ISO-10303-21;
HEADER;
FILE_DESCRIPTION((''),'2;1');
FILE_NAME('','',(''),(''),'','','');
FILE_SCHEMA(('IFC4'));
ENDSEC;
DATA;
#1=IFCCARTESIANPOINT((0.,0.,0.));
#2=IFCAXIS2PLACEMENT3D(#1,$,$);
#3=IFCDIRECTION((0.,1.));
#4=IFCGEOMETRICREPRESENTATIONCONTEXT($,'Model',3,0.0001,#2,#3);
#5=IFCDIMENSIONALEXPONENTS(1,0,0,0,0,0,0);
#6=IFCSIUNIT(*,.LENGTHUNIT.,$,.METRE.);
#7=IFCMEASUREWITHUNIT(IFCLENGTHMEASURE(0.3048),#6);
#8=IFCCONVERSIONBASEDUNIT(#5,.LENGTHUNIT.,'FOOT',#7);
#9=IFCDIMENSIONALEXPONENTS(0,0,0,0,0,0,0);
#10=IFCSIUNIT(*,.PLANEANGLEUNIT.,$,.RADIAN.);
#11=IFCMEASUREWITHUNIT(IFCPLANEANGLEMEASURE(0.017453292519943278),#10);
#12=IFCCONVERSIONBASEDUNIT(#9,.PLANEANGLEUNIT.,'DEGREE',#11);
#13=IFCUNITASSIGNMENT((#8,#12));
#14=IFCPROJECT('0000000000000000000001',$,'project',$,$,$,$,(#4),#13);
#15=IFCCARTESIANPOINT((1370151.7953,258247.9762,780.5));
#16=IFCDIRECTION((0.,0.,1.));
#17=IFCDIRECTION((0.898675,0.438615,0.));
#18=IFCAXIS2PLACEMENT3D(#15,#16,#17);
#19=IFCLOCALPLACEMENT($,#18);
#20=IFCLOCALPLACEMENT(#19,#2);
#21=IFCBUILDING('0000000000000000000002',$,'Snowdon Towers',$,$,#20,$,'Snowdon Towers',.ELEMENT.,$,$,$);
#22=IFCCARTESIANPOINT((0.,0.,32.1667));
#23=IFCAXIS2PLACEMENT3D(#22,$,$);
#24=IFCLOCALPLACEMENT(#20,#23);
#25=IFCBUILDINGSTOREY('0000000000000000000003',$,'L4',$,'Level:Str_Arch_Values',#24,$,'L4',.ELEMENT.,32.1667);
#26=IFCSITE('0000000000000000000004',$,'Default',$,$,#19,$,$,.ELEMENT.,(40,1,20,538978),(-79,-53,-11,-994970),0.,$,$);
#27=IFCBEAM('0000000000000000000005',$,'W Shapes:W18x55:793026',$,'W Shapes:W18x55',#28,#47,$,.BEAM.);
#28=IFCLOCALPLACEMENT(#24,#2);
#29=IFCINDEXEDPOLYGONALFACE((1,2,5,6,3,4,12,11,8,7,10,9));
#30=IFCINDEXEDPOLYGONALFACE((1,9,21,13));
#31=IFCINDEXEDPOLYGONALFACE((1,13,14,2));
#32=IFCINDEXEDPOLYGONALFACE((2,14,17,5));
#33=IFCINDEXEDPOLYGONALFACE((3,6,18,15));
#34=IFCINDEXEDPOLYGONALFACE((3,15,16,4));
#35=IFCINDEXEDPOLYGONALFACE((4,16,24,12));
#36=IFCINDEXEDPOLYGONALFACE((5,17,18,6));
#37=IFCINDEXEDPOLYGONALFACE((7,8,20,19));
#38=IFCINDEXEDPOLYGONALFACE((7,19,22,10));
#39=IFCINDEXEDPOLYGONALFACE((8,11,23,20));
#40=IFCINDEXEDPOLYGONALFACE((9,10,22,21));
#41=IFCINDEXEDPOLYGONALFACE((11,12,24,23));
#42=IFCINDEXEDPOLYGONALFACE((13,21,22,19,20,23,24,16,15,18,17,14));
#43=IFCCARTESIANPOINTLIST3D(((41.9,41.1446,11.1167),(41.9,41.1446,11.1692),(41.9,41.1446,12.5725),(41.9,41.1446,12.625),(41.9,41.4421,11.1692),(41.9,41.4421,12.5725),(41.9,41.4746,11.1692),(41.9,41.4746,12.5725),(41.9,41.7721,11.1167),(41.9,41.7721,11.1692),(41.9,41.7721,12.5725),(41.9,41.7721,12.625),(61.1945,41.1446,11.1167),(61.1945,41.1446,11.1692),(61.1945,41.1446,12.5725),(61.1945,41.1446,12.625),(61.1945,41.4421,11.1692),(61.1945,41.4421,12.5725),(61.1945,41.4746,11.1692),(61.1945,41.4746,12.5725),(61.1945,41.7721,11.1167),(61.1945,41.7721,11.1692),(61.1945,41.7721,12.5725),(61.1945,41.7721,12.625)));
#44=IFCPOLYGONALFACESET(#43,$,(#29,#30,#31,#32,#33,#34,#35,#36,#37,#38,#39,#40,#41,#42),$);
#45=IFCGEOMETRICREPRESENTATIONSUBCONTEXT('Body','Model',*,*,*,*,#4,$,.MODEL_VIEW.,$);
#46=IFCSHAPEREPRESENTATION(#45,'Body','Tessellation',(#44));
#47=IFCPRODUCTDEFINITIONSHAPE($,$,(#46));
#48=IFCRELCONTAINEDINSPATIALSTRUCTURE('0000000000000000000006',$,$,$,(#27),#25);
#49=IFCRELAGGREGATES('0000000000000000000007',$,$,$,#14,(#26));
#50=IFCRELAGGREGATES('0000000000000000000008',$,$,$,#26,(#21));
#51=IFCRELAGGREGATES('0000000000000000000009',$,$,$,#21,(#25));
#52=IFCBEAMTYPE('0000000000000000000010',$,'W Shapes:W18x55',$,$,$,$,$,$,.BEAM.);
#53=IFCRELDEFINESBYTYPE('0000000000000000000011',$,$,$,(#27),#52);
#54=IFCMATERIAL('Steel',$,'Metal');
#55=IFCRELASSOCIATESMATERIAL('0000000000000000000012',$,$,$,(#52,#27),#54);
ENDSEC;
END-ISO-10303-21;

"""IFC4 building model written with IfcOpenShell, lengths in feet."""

from ifc_helpers import new_model, entity, si_unit, converted_unit, direction, frame, origin, place, context, subcontext, project, spatial, indexed_curve, outline, extrude, source, transform, mapped, material, type_object, type_shapes, element, save


model = new_model("IFC4")

# Units and contexts
model_context = context("Model", 3, precision=0.0001, world=origin(), true_north=direction((0.0, 1.0)))
body_context = subcontext(model_context, "Body", "Model", "MODEL_VIEW")
ifc_project = project(units=[converted_unit("LENGTHUNIT", "FOOT", entity("IfcLengthMeasure", 0.3048), si_unit("LENGTHUNIT", "METRE"), dimensions=[1, 0, 0, 0, 0, 0, 0]), converted_unit("PLANEANGLEUNIT", "DEGREE", entity("IfcPlaneAngleMeasure", 0.017453292519943278), si_unit("PLANEANGLEUNIT", "RADIAN"), dimensions=[0, 0, 0, 0, 0, 0, 0])], contexts=[model_context])

# Site, building, storey
site_placement = place(None, frame((1370151.7953, 258247.9762, 780.5), z_axis=(0.0, 0.0, 1.0), x_axis=(0.898675, 0.438615, 0.0)))
site = spatial("IfcSite", under=ifc_project, at=site_placement, Name="Default", CompositionType="ELEMENT", RefLatitude=(40, 1, 20, 538978), RefLongitude=(-79, -53, -11, -994970), RefElevation=0.0)
building_placement = place(site_placement, origin())
building = spatial("IfcBuilding", under=site, at=building_placement, Name="Snowdon Towers", LongName="Snowdon Towers", CompositionType="ELEMENT")
storey_placement = place(building_placement, frame((0.0, 0.0, 32.1667)))
storey = spatial("IfcBuildingStorey", under=building, at=storey_placement, Name="L4", ObjectType="Level:Str_Arch_Values", LongName="L4", CompositionType="ELEMENT", Elevation=32.1667)

# Shared definitions
ifc_material = material(Name="Steel", Category="Metal")

# Beam
beam_type_1 = type_object("IfcBeamType", Name="W Shapes:W18x55", PredefinedType="BEAM", material=ifc_material)
shared_shape_1 = source(origin(), body_context, "Body", "SweptSolid", [
    extrude(outline(indexed_curve([(-0.3138, -0.7017), (-0.3138, -0.7542), (0.3138, -0.7542), (0.3138, -0.7017), (0.0162, -0.7017), (0.0162, 0.7017), (0.3138, 0.7017), (0.3138, 0.7542), (-0.3137, 0.7542), (-0.3137, 0.7017), (-0.0163, 0.7017), (-0.0163, -0.7017), (-0.3138, -0.7017)], self_intersect=False)), frame((-9.9242, 0.0, 0.0), z_axis=(-1.0, 0.0, 0.0), x_axis=(0.0, -1.0, 0.0)), (0.0, 0.0, -1.0), 19.2945),
])
type_shapes(beam_type_1, [shared_shape_1])
beam_1_placement = place(storey_placement, frame((51.8242, 41.4583, 11.8708)))
element("IfcBeam", 1, at=beam_1_placement, inside=storey, type_object=beam_type_1, material=ifc_material, Name="W Shapes:W18x55:793026", ObjectType="W Shapes:W18x55", PredefinedType="BEAM", context=body_context, shape_type="MappedRepresentation", body=[
    mapped(shared_shape_1, transform((0.0, 0.0, 0.0), scale=1.0)),
])

save(model, "model.ifc")
